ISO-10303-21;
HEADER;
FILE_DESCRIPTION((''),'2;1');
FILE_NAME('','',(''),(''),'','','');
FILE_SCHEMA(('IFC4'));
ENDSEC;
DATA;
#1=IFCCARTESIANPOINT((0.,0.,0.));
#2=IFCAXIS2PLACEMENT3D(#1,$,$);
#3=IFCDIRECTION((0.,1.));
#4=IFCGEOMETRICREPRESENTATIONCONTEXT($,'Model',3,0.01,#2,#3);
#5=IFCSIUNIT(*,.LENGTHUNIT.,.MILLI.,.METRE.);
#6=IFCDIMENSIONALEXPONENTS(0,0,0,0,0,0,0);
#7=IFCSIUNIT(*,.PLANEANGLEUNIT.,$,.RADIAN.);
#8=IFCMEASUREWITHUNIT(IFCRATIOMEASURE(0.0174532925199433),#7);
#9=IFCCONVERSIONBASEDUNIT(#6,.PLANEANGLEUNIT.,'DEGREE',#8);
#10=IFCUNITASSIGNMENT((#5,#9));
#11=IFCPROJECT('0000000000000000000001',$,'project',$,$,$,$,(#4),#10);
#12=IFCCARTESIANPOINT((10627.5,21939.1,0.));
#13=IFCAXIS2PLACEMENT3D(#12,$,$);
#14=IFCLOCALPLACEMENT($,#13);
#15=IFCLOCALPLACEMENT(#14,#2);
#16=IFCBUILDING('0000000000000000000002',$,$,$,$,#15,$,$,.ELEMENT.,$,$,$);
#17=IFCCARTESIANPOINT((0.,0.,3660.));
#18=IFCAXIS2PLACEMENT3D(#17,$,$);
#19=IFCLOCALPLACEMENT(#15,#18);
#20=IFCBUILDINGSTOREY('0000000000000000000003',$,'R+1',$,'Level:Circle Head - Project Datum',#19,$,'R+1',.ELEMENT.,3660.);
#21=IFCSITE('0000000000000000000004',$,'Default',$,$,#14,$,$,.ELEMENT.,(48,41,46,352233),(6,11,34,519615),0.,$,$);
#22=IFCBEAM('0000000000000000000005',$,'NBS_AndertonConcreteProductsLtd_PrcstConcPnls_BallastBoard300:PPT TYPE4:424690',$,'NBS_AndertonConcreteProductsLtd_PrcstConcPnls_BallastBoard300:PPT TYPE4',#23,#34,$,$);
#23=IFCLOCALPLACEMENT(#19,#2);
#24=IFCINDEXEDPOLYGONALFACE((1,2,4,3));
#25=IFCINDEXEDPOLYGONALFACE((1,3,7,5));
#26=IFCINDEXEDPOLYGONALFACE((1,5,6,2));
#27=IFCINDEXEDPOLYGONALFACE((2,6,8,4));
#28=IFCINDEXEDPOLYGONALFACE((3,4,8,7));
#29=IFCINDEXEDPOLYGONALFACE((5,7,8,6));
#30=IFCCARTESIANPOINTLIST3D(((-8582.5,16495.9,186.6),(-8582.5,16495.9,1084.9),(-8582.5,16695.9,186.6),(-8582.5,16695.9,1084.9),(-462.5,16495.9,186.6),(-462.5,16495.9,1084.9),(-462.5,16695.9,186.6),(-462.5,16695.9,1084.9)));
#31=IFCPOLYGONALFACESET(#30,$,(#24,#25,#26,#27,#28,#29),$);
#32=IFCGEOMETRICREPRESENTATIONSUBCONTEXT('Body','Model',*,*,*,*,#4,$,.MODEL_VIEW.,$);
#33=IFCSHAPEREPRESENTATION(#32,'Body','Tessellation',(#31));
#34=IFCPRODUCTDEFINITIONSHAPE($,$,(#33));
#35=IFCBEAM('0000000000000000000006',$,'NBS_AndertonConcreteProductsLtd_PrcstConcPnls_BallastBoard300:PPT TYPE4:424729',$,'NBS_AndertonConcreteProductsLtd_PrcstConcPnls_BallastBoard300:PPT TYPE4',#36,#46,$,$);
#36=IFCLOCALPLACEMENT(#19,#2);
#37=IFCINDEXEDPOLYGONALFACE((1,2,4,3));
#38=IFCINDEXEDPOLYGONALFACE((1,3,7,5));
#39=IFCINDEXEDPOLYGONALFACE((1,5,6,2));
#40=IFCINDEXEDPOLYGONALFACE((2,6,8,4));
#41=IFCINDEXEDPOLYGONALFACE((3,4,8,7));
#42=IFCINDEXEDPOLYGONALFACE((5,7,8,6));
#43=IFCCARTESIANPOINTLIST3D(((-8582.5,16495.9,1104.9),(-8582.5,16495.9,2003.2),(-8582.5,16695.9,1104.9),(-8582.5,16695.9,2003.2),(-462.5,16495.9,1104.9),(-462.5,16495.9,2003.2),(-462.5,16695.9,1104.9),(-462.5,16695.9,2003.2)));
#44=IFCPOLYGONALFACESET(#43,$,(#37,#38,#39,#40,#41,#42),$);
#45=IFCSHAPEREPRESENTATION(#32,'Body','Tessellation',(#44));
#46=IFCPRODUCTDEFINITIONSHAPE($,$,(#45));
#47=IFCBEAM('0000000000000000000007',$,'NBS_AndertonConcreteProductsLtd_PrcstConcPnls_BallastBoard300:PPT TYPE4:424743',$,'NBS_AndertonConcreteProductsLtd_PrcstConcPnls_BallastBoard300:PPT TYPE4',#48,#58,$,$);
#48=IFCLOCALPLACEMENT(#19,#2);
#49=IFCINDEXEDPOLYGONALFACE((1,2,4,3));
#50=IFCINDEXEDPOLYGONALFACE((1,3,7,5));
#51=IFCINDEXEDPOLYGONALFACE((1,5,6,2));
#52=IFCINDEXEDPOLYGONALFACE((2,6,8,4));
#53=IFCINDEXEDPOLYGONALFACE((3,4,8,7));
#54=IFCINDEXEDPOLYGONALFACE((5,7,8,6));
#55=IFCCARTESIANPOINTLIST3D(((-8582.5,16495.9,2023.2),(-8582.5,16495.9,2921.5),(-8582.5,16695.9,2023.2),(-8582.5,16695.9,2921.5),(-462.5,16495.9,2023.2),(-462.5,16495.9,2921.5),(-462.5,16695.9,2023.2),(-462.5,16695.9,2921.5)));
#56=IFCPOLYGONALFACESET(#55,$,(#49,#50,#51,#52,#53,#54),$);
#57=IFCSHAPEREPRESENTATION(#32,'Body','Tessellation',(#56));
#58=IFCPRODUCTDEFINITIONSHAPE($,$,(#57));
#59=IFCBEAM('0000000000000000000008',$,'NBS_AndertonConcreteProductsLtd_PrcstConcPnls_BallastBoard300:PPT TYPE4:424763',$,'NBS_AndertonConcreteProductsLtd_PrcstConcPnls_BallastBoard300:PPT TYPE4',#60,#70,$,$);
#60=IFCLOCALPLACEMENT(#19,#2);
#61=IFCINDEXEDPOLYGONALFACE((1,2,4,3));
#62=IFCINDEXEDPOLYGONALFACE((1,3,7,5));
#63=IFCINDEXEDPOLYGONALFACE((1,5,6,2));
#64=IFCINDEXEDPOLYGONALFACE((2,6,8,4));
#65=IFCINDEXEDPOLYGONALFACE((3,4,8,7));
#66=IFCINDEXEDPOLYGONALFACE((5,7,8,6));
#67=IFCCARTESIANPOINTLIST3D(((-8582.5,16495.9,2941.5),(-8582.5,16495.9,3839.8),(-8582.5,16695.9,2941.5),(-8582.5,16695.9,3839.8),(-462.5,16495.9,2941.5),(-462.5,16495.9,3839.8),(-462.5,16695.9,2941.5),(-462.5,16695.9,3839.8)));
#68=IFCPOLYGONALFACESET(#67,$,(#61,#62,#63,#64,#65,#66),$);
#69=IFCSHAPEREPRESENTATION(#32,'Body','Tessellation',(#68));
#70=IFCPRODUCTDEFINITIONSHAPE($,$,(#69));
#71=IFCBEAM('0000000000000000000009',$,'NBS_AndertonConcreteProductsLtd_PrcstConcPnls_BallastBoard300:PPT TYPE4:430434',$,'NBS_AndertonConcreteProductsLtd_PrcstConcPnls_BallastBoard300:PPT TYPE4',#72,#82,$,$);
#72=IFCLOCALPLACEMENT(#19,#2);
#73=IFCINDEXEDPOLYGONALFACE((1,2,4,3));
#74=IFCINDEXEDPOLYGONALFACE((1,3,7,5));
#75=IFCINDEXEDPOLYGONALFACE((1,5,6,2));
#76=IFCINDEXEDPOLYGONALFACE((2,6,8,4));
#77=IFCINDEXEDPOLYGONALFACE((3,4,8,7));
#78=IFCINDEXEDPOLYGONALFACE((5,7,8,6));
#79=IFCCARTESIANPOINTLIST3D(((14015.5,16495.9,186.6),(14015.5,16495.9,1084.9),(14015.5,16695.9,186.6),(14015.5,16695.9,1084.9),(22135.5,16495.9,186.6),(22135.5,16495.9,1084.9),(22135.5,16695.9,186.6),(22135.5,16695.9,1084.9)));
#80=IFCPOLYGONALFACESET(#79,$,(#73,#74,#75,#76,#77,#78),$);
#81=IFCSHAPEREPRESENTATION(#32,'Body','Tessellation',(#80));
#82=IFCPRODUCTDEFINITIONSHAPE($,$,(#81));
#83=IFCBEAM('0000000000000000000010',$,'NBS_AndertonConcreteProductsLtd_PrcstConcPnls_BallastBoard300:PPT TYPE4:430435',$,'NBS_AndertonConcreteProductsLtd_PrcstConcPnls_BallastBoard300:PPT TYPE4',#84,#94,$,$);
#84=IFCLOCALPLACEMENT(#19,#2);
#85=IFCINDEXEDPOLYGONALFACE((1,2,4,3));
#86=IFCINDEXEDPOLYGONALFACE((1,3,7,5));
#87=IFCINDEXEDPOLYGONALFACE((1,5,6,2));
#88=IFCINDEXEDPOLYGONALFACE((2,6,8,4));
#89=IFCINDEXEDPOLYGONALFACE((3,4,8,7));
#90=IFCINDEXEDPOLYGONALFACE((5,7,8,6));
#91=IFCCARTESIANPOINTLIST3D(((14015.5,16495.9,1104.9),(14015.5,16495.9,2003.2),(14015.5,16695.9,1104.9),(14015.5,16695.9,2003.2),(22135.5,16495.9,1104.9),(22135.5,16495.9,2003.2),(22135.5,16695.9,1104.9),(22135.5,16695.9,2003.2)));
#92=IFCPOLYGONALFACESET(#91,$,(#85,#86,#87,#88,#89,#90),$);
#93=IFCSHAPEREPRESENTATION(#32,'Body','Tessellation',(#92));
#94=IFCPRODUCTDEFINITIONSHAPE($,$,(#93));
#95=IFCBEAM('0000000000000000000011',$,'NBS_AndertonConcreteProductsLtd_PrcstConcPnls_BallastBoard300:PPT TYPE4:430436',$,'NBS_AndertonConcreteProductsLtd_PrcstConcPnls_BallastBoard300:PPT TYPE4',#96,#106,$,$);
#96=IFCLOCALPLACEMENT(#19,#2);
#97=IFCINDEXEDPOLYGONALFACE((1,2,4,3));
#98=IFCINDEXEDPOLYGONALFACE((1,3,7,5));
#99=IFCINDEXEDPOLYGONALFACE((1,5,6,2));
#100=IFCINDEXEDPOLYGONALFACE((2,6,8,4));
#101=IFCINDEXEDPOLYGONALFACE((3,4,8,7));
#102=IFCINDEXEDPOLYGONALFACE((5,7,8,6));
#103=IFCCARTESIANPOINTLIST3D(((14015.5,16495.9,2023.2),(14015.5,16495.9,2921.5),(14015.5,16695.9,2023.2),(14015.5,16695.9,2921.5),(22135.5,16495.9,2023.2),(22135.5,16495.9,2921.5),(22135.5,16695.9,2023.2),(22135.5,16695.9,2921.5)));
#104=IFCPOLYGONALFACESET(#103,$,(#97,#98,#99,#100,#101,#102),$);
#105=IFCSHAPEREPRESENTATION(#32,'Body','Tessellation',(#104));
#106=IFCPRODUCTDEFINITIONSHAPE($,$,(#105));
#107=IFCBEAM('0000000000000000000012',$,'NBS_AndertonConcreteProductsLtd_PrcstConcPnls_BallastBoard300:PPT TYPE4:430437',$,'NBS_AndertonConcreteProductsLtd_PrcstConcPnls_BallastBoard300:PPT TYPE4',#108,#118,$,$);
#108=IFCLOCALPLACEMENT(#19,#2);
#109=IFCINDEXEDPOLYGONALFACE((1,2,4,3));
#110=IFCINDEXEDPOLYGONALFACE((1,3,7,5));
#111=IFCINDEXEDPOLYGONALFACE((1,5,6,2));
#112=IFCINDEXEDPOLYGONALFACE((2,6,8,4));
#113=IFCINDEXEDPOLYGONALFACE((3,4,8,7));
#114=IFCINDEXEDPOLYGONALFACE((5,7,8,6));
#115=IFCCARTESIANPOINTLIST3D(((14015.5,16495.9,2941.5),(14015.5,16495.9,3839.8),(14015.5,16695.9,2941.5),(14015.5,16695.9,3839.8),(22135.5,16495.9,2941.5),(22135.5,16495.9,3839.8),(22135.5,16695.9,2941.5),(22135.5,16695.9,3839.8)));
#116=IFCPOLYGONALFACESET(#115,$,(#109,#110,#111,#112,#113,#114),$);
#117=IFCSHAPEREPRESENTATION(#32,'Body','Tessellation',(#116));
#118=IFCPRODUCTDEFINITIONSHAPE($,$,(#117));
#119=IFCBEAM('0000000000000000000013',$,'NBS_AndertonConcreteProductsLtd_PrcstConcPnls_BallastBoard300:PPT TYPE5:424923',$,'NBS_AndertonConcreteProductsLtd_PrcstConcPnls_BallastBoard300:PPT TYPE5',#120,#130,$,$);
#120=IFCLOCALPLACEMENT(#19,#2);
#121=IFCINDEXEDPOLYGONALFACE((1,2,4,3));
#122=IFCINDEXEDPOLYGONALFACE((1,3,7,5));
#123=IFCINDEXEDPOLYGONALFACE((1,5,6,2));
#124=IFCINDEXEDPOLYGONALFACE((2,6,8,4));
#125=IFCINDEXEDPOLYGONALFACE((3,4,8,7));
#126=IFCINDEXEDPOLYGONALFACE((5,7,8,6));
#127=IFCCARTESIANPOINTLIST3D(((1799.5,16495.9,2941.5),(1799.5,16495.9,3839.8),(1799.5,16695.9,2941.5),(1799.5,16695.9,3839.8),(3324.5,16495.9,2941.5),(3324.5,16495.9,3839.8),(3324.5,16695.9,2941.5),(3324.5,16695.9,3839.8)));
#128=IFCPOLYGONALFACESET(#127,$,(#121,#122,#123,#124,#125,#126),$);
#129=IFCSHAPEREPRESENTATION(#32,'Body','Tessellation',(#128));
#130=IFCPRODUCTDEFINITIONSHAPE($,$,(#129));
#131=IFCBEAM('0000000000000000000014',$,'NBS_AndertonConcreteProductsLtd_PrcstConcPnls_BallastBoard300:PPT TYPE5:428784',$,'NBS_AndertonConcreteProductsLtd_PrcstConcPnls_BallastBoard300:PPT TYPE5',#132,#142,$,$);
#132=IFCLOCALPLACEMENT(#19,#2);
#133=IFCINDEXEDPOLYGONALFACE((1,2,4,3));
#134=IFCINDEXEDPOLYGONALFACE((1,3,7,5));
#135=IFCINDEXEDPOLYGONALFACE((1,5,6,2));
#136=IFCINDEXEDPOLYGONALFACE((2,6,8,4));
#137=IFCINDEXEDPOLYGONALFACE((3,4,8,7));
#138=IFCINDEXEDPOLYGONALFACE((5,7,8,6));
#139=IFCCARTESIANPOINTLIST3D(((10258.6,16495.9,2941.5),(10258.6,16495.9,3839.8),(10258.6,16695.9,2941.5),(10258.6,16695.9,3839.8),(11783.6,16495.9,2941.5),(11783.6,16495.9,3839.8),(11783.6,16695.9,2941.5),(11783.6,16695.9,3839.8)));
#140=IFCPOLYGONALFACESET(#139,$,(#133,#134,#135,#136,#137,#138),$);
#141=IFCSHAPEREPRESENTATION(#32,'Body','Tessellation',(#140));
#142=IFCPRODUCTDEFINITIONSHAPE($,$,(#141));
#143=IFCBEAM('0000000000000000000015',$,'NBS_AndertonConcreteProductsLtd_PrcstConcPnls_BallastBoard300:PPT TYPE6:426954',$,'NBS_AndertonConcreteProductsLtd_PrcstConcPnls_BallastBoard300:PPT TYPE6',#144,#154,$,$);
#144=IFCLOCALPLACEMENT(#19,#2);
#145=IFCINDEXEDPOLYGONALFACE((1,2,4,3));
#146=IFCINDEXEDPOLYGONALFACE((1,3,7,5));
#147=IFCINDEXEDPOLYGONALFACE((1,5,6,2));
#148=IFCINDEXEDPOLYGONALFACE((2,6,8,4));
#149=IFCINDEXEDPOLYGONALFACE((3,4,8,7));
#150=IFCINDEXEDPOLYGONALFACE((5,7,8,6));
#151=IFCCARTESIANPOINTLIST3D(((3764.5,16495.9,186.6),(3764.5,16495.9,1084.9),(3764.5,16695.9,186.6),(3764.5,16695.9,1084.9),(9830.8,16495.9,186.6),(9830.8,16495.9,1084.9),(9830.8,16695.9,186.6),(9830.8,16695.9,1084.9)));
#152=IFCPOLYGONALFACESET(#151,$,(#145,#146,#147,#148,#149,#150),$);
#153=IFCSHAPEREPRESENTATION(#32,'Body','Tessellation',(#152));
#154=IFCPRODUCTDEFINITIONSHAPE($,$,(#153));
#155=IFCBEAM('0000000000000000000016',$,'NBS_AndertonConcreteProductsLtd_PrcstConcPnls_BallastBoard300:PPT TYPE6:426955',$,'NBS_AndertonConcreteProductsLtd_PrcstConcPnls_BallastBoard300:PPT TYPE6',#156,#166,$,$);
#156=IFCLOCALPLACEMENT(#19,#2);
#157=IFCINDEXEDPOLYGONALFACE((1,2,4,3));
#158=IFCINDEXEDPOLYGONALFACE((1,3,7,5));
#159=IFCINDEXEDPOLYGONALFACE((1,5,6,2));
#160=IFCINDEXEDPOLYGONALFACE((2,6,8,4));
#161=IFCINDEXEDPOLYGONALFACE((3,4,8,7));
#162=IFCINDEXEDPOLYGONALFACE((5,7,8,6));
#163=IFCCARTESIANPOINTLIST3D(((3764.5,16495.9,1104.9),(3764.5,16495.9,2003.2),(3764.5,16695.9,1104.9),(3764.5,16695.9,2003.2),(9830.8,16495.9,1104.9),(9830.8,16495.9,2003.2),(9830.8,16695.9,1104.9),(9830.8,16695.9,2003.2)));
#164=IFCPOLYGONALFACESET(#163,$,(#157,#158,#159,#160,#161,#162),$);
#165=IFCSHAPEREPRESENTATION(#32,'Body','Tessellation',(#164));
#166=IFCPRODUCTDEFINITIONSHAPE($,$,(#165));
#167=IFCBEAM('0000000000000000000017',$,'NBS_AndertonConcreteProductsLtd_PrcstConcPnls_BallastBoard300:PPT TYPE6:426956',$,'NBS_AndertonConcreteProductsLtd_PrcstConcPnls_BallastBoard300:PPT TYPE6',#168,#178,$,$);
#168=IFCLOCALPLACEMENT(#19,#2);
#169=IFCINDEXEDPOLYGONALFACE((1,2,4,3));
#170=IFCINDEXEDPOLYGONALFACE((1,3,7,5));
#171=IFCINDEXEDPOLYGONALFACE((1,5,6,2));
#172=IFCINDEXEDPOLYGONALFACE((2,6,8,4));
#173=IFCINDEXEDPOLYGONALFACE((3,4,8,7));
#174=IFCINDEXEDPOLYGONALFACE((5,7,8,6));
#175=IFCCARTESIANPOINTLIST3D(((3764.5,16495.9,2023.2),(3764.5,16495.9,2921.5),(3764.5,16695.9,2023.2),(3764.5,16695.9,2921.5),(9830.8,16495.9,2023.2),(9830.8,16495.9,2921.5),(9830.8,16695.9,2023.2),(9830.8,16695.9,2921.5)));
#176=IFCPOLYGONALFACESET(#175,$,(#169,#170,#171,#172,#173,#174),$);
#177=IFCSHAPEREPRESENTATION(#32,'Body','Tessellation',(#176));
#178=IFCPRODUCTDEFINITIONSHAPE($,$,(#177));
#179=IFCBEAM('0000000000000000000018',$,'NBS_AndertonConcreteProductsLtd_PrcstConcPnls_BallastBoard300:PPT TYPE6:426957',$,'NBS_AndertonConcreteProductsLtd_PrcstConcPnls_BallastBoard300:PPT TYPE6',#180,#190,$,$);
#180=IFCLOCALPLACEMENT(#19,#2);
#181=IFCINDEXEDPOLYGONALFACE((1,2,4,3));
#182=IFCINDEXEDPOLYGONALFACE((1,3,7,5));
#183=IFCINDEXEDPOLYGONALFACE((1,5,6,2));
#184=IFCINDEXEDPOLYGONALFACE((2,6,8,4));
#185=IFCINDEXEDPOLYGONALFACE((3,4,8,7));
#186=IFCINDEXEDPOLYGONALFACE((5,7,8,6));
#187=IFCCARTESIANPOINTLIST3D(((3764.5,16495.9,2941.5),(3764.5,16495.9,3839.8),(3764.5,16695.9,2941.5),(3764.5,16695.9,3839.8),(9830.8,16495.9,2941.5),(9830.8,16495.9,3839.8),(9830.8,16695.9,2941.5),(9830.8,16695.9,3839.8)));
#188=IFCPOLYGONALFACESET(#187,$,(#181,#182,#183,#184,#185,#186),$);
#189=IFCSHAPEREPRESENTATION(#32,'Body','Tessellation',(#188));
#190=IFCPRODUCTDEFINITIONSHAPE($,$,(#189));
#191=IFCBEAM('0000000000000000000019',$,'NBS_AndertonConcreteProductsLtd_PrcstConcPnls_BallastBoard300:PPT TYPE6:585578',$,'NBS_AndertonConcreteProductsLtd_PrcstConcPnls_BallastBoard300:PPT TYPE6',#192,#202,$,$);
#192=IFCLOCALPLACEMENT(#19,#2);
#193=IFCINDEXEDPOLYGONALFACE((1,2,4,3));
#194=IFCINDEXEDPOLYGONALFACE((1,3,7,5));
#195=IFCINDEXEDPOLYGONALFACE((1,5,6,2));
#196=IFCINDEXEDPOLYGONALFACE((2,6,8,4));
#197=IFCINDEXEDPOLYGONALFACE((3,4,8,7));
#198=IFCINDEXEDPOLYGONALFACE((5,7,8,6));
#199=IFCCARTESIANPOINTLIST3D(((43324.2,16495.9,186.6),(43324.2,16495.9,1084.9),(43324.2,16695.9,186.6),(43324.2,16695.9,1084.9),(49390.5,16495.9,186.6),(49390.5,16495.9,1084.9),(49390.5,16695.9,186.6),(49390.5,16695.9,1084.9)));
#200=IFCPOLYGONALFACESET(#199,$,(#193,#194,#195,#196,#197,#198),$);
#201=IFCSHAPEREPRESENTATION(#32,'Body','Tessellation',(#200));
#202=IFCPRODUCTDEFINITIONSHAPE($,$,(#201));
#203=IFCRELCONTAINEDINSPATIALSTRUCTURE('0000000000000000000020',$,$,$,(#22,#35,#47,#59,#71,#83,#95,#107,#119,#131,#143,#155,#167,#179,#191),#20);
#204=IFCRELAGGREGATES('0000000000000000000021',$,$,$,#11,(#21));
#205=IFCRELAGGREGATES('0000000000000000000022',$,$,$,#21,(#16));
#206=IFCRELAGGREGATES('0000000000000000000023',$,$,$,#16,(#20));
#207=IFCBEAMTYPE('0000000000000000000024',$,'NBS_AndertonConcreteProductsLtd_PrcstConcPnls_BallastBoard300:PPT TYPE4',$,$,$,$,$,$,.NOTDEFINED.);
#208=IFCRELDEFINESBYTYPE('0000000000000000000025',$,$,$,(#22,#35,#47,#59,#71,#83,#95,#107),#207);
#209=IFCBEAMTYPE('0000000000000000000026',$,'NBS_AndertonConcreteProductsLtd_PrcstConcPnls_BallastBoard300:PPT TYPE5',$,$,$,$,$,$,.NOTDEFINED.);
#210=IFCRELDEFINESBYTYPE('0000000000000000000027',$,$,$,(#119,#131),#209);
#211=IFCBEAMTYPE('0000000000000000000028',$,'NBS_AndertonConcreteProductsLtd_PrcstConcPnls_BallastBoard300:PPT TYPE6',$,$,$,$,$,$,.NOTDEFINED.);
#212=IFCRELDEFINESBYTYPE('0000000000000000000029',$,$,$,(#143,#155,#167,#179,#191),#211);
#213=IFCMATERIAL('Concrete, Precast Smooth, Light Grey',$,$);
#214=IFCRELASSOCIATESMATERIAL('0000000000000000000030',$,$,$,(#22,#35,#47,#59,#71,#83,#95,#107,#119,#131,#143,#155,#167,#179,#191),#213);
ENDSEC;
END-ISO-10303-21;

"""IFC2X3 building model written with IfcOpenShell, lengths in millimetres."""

from ifc_helpers import new_model, entity, si_unit, converted_unit, direction, frame, frame_2d, origin, place, context, subcontext, project, spatial, rectangle, extrude, material, type_object, element, save


model = new_model("IFC2X3")

# Units and contexts
model_context = context("Model", 3, precision=0.01, world=origin(), true_north=direction((0.0, 1.0)))
body_context = subcontext(model_context, "Body", "Model", "MODEL_VIEW")
ifc_project = project(units=[si_unit("LENGTHUNIT", "METRE", prefix="MILLI"), converted_unit("PLANEANGLEUNIT", "DEGREE", entity("IfcRatioMeasure", 0.0174532925199433), si_unit("PLANEANGLEUNIT", "RADIAN"), dimensions=[0, 0, 0, 0, 0, 0, 0])], contexts=[model_context])

# Site, building, storey
site_placement = place(None, frame((10627.5, 21939.1, 0.0)))
site = spatial("IfcSite", under=ifc_project, at=site_placement, Name="Default", CompositionType="ELEMENT", RefLatitude=(48, 41, 46, 352233), RefLongitude=(6, 11, 34, 519615), RefElevation=0.0)
building_placement = place(site_placement, origin())
building = spatial("IfcBuilding", under=site, at=building_placement, CompositionType="ELEMENT")
storey_placement = place(building_placement, frame((0.0, 0.0, 3660.0)))
storey = spatial("IfcBuildingStorey", under=building, at=storey_placement, Name="R+1", ObjectType="Level:Circle Head - Project Datum", LongName="R+1", CompositionType="ELEMENT", Elevation=3660.0)

# Beams
ifc_material = material(Name="Concrete, Precast Smooth, Light Grey")
beam_type_1 = type_object("IfcBeamType", Name="NBS_AndertonConcreteProductsLtd_PrcstConcPnls_BallastBoard300:PPT TYPE4", PredefinedType="NOTDEFINED")
beam_1_placement = place(storey_placement, origin())
element("IfcBeam", 1, at=beam_1_placement, inside=storey, type_object=beam_type_1, material=ifc_material, Name="NBS_AndertonConcreteProductsLtd_PrcstConcPnls_BallastBoard300:PPT TYPE4:424690", ObjectType="NBS_AndertonConcreteProductsLtd_PrcstConcPnls_BallastBoard300:PPT TYPE4", context=body_context, shape_type="SweptSolid", body=[
    extrude(rectangle(XDim=898.3, YDim=200.0, at=frame_2d((0.0, 0.0), x_axis=(0.0, 1.0))), frame((-8582.5, 16595.9, 635.8), z_axis=(1.0, 0.0, 0.0), x_axis=(0.0, 1.0, 0.0)), (0.0, 0.0, 1.0), 8120.0),
])
beam_2_placement = place(storey_placement, origin())
element("IfcBeam", 2, at=beam_2_placement, inside=storey, type_object=beam_type_1, material=ifc_material, Name="NBS_AndertonConcreteProductsLtd_PrcstConcPnls_BallastBoard300:PPT TYPE4:424729", ObjectType="NBS_AndertonConcreteProductsLtd_PrcstConcPnls_BallastBoard300:PPT TYPE4", context=body_context, shape_type="SweptSolid", body=[
    extrude(rectangle(XDim=898.3, YDim=200.0, at=frame_2d((0.0, 0.0), x_axis=(0.0, 1.0))), frame((-8582.5, 16595.9, 1554.1), z_axis=(1.0, 0.0, 0.0), x_axis=(0.0, 1.0, 0.0)), (0.0, 0.0, 1.0), 8120.0),
])
beam_3_placement = place(storey_placement, origin())
element("IfcBeam", 3, at=beam_3_placement, inside=storey, type_object=beam_type_1, material=ifc_material, Name="NBS_AndertonConcreteProductsLtd_PrcstConcPnls_BallastBoard300:PPT TYPE4:424743", ObjectType="NBS_AndertonConcreteProductsLtd_PrcstConcPnls_BallastBoard300:PPT TYPE4", context=body_context, shape_type="SweptSolid", body=[
    extrude(rectangle(XDim=898.3, YDim=200.0, at=frame_2d((0.0, 0.0), x_axis=(0.0, 1.0))), frame((-8582.5, 16595.9, 2472.4), z_axis=(1.0, 0.0, 0.0), x_axis=(0.0, 1.0, 0.0)), (0.0, 0.0, 1.0), 8120.0),
])
beam_4_placement = place(storey_placement, origin())
element("IfcBeam", 4, at=beam_4_placement, inside=storey, type_object=beam_type_1, material=ifc_material, Name="NBS_AndertonConcreteProductsLtd_PrcstConcPnls_BallastBoard300:PPT TYPE4:424763", ObjectType="NBS_AndertonConcreteProductsLtd_PrcstConcPnls_BallastBoard300:PPT TYPE4", context=body_context, shape_type="SweptSolid", body=[
    extrude(rectangle(XDim=898.3, YDim=200.0, at=frame_2d((0.0, 0.0), x_axis=(0.0, 1.0))), frame((-8582.5, 16595.9, 3390.7), z_axis=(1.0, 0.0, 0.0), x_axis=(0.0, 1.0, 0.0)), (0.0, 0.0, 1.0), 8120.0),
])
beam_5_placement = place(storey_placement, origin())
element("IfcBeam", 5, at=beam_5_placement, inside=storey, type_object=beam_type_1, material=ifc_material, Name="NBS_AndertonConcreteProductsLtd_PrcstConcPnls_BallastBoard300:PPT TYPE4:430434", ObjectType="NBS_AndertonConcreteProductsLtd_PrcstConcPnls_BallastBoard300:PPT TYPE4", context=body_context, shape_type="SweptSolid", body=[
    extrude(rectangle(XDim=898.3, YDim=200.0, at=frame_2d((0.0, 0.0), x_axis=(0.0, 1.0))), frame((14015.5, 16595.9, 635.8), z_axis=(1.0, 0.0, 0.0), x_axis=(0.0, 1.0, 0.0)), (0.0, 0.0, 1.0), 8120.0),
])
beam_6_placement = place(storey_placement, origin())
element("IfcBeam", 6, at=beam_6_placement, inside=storey, type_object=beam_type_1, material=ifc_material, Name="NBS_AndertonConcreteProductsLtd_PrcstConcPnls_BallastBoard300:PPT TYPE4:430435", ObjectType="NBS_AndertonConcreteProductsLtd_PrcstConcPnls_BallastBoard300:PPT TYPE4", context=body_context, shape_type="SweptSolid", body=[
    extrude(rectangle(XDim=898.3, YDim=200.0, at=frame_2d((0.0, 0.0), x_axis=(0.0, 1.0))), frame((14015.5, 16595.9, 1554.1), z_axis=(1.0, 0.0, 0.0), x_axis=(0.0, 1.0, 0.0)), (0.0, 0.0, 1.0), 8120.0),
])
beam_7_placement = place(storey_placement, origin())
element("IfcBeam", 7, at=beam_7_placement, inside=storey, type_object=beam_type_1, material=ifc_material, Name="NBS_AndertonConcreteProductsLtd_PrcstConcPnls_BallastBoard300:PPT TYPE4:430436", ObjectType="NBS_AndertonConcreteProductsLtd_PrcstConcPnls_BallastBoard300:PPT TYPE4", context=body_context, shape_type="SweptSolid", body=[
    extrude(rectangle(XDim=898.3, YDim=200.0, at=frame_2d((0.0, 0.0), x_axis=(0.0, 1.0))), frame((14015.5, 16595.9, 2472.4), z_axis=(1.0, 0.0, 0.0), x_axis=(0.0, 1.0, 0.0)), (0.0, 0.0, 1.0), 8120.0),
])
beam_8_placement = place(storey_placement, origin())
element("IfcBeam", 8, at=beam_8_placement, inside=storey, type_object=beam_type_1, material=ifc_material, Name="NBS_AndertonConcreteProductsLtd_PrcstConcPnls_BallastBoard300:PPT TYPE4:430437", ObjectType="NBS_AndertonConcreteProductsLtd_PrcstConcPnls_BallastBoard300:PPT TYPE4", context=body_context, shape_type="SweptSolid", body=[
    extrude(rectangle(XDim=898.3, YDim=200.0, at=frame_2d((0.0, 0.0), x_axis=(0.0, 1.0))), frame((14015.5, 16595.9, 3390.7), z_axis=(1.0, 0.0, 0.0), x_axis=(0.0, 1.0, 0.0)), (0.0, 0.0, 1.0), 8120.0),
])
beam_type_2 = type_object("IfcBeamType", Name="NBS_AndertonConcreteProductsLtd_PrcstConcPnls_BallastBoard300:PPT TYPE5", PredefinedType="NOTDEFINED")
beam_9_placement = place(storey_placement, origin())
element("IfcBeam", 9, at=beam_9_placement, inside=storey, type_object=beam_type_2, material=ifc_material, Name="NBS_AndertonConcreteProductsLtd_PrcstConcPnls_BallastBoard300:PPT TYPE5:424923", ObjectType="NBS_AndertonConcreteProductsLtd_PrcstConcPnls_BallastBoard300:PPT TYPE5", context=body_context, shape_type="SweptSolid", body=[
    extrude(rectangle(XDim=898.3, YDim=200.0, at=frame_2d((0.0, 0.0), x_axis=(0.0, 1.0))), frame((1799.5, 16595.9, 3390.7), z_axis=(1.0, 0.0, 0.0), x_axis=(0.0, 1.0, 0.0)), (0.0, 0.0, 1.0), 1525.0),
])
beam_10_placement = place(storey_placement, origin())
element("IfcBeam", 10, at=beam_10_placement, inside=storey, type_object=beam_type_2, material=ifc_material, Name="NBS_AndertonConcreteProductsLtd_PrcstConcPnls_BallastBoard300:PPT TYPE5:428784", ObjectType="NBS_AndertonConcreteProductsLtd_PrcstConcPnls_BallastBoard300:PPT TYPE5", context=body_context, shape_type="SweptSolid", body=[
    extrude(rectangle(XDim=898.3, YDim=200.0, at=frame_2d((0.0, 0.0), x_axis=(0.0, 1.0))), frame((10258.6, 16595.9, 3390.7), z_axis=(1.0, 0.0, 0.0), x_axis=(0.0, 1.0, 0.0)), (0.0, 0.0, 1.0), 1525.0),
])
beam_type_3 = type_object("IfcBeamType", Name="NBS_AndertonConcreteProductsLtd_PrcstConcPnls_BallastBoard300:PPT TYPE6", PredefinedType="NOTDEFINED")
beam_11_placement = place(storey_placement, origin())
element("IfcBeam", 11, at=beam_11_placement, inside=storey, type_object=beam_type_3, material=ifc_material, Name="NBS_AndertonConcreteProductsLtd_PrcstConcPnls_BallastBoard300:PPT TYPE6:426954", ObjectType="NBS_AndertonConcreteProductsLtd_PrcstConcPnls_BallastBoard300:PPT TYPE6", context=body_context, shape_type="SweptSolid", body=[
    extrude(rectangle(XDim=898.3, YDim=200.0, at=frame_2d((0.0, 0.0), x_axis=(0.0, 1.0))), frame((3764.5, 16595.9, 635.8), z_axis=(1.0, 0.0, 0.0), x_axis=(0.0, 1.0, 0.0)), (0.0, 0.0, 1.0), 6066.3),
])
beam_12_placement = place(storey_placement, origin())
element("IfcBeam", 12, at=beam_12_placement, inside=storey, type_object=beam_type_3, material=ifc_material, Name="NBS_AndertonConcreteProductsLtd_PrcstConcPnls_BallastBoard300:PPT TYPE6:426955", ObjectType="NBS_AndertonConcreteProductsLtd_PrcstConcPnls_BallastBoard300:PPT TYPE6", context=body_context, shape_type="SweptSolid", body=[
    extrude(rectangle(XDim=898.3, YDim=200.0, at=frame_2d((0.0, 0.0), x_axis=(0.0, 1.0))), frame((3764.5, 16595.9, 1554.1), z_axis=(1.0, 0.0, 0.0), x_axis=(0.0, 1.0, 0.0)), (0.0, 0.0, 1.0), 6066.3),
])
beam_13_placement = place(storey_placement, origin())
element("IfcBeam", 13, at=beam_13_placement, inside=storey, type_object=beam_type_3, material=ifc_material, Name="NBS_AndertonConcreteProductsLtd_PrcstConcPnls_BallastBoard300:PPT TYPE6:426956", ObjectType="NBS_AndertonConcreteProductsLtd_PrcstConcPnls_BallastBoard300:PPT TYPE6", context=body_context, shape_type="SweptSolid", body=[
    extrude(rectangle(XDim=898.3, YDim=200.0, at=frame_2d((0.0, 0.0), x_axis=(0.0, 1.0))), frame((3764.5, 16595.9, 2472.4), z_axis=(1.0, 0.0, 0.0), x_axis=(0.0, 1.0, 0.0)), (0.0, 0.0, 1.0), 6066.3),
])
beam_14_placement = place(storey_placement, origin())
element("IfcBeam", 14, at=beam_14_placement, inside=storey, type_object=beam_type_3, material=ifc_material, Name="NBS_AndertonConcreteProductsLtd_PrcstConcPnls_BallastBoard300:PPT TYPE6:426957", ObjectType="NBS_AndertonConcreteProductsLtd_PrcstConcPnls_BallastBoard300:PPT TYPE6", context=body_context, shape_type="SweptSolid", body=[
    extrude(rectangle(XDim=898.3, YDim=200.0, at=frame_2d((0.0, 0.0), x_axis=(0.0, 1.0))), frame((3764.5, 16595.9, 3390.7), z_axis=(1.0, 0.0, 0.0), x_axis=(0.0, 1.0, 0.0)), (0.0, 0.0, 1.0), 6066.3),
])
beam_15_placement = place(storey_placement, origin())
element("IfcBeam", 15, at=beam_15_placement, inside=storey, type_object=beam_type_3, material=ifc_material, Name="NBS_AndertonConcreteProductsLtd_PrcstConcPnls_BallastBoard300:PPT TYPE6:585578", ObjectType="NBS_AndertonConcreteProductsLtd_PrcstConcPnls_BallastBoard300:PPT TYPE6", context=body_context, shape_type="SweptSolid", body=[
    extrude(rectangle(XDim=898.3, YDim=200.0, at=frame_2d((0.0, 0.0), x_axis=(1.0, 0.0))), frame((43324.2, 16595.9, 635.8), z_axis=(1.0, 0.0, 0.0), x_axis=(0.0, 0.0, -1.0)), (0.0, 0.0, 1.0), 6066.3),
])

save(model, "model.ifc")
